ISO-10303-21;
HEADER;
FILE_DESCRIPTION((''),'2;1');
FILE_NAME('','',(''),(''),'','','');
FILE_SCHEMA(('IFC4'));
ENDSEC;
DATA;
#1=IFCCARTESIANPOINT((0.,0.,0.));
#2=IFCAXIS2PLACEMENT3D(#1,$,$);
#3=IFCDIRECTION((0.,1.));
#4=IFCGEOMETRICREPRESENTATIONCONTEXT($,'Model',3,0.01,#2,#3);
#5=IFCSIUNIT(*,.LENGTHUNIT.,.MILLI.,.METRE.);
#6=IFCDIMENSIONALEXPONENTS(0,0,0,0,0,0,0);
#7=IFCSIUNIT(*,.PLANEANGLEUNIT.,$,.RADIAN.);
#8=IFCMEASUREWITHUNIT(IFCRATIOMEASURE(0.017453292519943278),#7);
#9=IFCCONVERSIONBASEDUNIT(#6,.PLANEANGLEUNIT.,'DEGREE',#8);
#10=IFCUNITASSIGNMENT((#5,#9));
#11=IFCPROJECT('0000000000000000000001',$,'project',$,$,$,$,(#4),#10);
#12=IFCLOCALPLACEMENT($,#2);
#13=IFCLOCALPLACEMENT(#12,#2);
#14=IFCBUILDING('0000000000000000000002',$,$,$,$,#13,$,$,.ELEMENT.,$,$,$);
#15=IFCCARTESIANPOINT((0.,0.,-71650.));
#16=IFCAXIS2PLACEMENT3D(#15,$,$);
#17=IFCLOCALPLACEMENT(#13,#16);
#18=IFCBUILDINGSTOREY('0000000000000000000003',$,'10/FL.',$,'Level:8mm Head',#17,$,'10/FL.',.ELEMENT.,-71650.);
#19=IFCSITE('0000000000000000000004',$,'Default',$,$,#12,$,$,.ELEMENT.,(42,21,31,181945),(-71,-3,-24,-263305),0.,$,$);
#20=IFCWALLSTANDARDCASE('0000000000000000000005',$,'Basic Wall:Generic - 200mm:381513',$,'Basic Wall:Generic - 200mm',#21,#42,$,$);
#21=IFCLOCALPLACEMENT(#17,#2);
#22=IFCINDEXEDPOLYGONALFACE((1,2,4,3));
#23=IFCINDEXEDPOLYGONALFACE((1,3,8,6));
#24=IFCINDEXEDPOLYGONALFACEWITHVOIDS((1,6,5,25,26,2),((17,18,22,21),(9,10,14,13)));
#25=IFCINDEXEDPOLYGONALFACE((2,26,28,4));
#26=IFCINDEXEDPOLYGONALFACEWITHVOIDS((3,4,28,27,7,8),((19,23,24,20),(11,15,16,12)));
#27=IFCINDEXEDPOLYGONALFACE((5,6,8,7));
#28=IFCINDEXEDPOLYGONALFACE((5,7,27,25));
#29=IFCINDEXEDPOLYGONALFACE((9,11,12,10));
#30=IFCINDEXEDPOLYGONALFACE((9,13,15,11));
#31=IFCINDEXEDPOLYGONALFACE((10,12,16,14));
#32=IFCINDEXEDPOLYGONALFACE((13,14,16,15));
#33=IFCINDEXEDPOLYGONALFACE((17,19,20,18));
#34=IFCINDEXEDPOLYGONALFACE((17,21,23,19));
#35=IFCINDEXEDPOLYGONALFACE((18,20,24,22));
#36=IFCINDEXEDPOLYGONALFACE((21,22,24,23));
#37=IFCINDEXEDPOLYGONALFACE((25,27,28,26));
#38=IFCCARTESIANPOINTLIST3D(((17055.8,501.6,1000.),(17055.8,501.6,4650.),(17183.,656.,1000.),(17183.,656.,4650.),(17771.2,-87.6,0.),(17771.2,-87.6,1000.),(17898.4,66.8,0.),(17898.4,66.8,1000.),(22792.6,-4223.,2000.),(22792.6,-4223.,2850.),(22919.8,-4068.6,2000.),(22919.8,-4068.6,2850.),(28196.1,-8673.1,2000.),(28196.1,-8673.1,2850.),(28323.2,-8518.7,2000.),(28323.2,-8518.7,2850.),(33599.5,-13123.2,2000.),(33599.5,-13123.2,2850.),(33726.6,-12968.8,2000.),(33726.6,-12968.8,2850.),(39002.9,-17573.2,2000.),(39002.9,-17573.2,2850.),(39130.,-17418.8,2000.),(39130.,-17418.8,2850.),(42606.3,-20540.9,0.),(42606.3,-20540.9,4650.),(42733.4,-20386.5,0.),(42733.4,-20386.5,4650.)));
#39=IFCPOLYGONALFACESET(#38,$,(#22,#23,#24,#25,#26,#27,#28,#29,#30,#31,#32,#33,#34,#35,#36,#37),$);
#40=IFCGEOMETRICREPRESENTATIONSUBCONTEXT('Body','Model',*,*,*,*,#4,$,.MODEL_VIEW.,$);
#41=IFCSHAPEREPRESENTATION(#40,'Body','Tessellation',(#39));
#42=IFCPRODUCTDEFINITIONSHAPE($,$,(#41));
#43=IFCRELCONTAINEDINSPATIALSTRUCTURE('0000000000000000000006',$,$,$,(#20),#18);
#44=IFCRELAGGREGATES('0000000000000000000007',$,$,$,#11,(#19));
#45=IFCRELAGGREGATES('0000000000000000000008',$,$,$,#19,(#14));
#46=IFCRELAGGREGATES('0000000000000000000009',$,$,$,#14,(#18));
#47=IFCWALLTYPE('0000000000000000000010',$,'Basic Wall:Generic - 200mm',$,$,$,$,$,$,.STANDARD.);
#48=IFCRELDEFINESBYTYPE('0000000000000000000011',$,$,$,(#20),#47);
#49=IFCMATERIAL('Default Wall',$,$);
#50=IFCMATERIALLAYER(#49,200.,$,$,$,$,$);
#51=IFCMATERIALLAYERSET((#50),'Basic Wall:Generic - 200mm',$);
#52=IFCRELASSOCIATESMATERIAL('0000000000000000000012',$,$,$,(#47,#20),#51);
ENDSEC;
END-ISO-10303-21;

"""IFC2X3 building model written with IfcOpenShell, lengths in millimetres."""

from ifc_helpers import new_model, entity, si_unit, converted_unit, direction, frame, frame_2d, origin, place, context, subcontext, project, spatial, rectangle, extrude, material, layer, layer_set, layer_usage, type_object, element, save


model = new_model("IFC2X3")

# Units and contexts
model_context = context("Model", 3, precision=0.01, world=origin(), true_north=direction((0.0, 1.0)))
body_context = subcontext(model_context, "Body", "Model", "MODEL_VIEW")
ifc_project = project(units=[si_unit("LENGTHUNIT", "METRE", prefix="MILLI"), converted_unit("PLANEANGLEUNIT", "DEGREE", entity("IfcRatioMeasure", 0.017453292519943278), si_unit("PLANEANGLEUNIT", "RADIAN"), dimensions=[0, 0, 0, 0, 0, 0, 0])], contexts=[model_context])

# Site, building, storey
site_placement = place(None, origin())
site = spatial("IfcSite", under=ifc_project, at=site_placement, Name="Default", CompositionType="ELEMENT", RefLatitude=(42, 21, 31, 181945), RefLongitude=(-71, -3, -24, -263305), RefElevation=0.0)
building_placement = place(site_placement, origin())
building = spatial("IfcBuilding", under=site, at=building_placement, CompositionType="ELEMENT")
storey_placement = place(building_placement, frame((0.0, 0.0, -71650.0)))
storey = spatial("IfcBuildingStorey", under=building, at=storey_placement, Name="10/FL.", ObjectType="Level:8mm Head", LongName="10/FL.", CompositionType="ELEMENT", Elevation=-71650.0)

# Wall, openings
ifc_material_1 = material(Name="Default Wall")
ifc_layer = layer(ifc_material_1, 200.0)
ifc_layer_set = layer_set([ifc_layer], Name="Basic Wall:Generic - 200mm")
ifc_layer_usage = layer_usage(ifc_layer_set, "AXIS2", "NEGATIVE", 100.0)
wall_type = type_object("IfcWallType", Name="Basic Wall:Generic - 200mm", PredefinedType="STANDARD", material=ifc_layer_set)
wall_1_placement = place(storey_placement, frame((42669.9, -20463.7, 0.0), z_axis=(0.0, 0.0, 1.0), x_axis=(-0.771917, 0.635723, 0.0)))
wall_1 = element("IfcWallStandardCase", 1, at=wall_1_placement, inside=storey, type_object=wall_type, material=ifc_layer_usage, Name="Basic Wall:Generic - 200mm:381513", ObjectType="Basic Wall:Generic - 200mm", context=body_context, shape_type="SweptSolid", body=[
    extrude(rectangle(XDim=33100.0, YDim=200.0, at=frame_2d((16550.0, 0.0), x_axis=(-1.0, 0.0))), origin(), (0.0, 0.0, 1.0), 4650.0),
])
opening_1_placement = place(wall_1_placement, origin())
element("IfcOpeningElement", 2, at=opening_1_placement, cuts=wall_1, ObjectType="Opening", context=body_context, shape_type="SweptSolid", body=[
    extrude(rectangle(XDim=850.0, YDim=7000.0, at=frame_2d((0.0, 0.0), x_axis=(1.0, 0.0))), frame((8168.1, -100.0, 2425.0), z_axis=(0.0, 1.0, 0.0), x_axis=(0.0, 0.0, -1.0)), (0.0, 0.0, 1.0), 200.0),
])
opening_2_placement = place(wall_1_placement, origin())
element("IfcOpeningElement", 3, at=opening_2_placement, cuts=wall_1, ObjectType="Opening", context=body_context, shape_type="SweptSolid", body=[
    extrude(rectangle(XDim=850.0, YDim=7000.0, at=frame_2d((0.0, 0.0), x_axis=(1.0, 0.0))), frame((22168.1, -100.0, 2425.0), z_axis=(0.0, 1.0, 0.0), x_axis=(0.0, 0.0, -1.0)), (0.0, 0.0, 1.0), 200.0),
])
opening_3_placement = place(wall_1_placement, frame((45946.8, 11330.0, 0.0), z_axis=(0.0, 0.0, 1.0), x_axis=(-0.771917, -0.635723, 0.0)))
element("IfcOpeningElement", 4, at=opening_3_placement, cuts=wall_1, ObjectType="Opening", context=body_context, shape_type="SweptSolid", body=[
    extrude(rectangle(XDim=1000.0, YDim=1010.1, at=frame_2d((0.0, 0.0), x_axis=(1.0, 0.0))), frame((17516.6, 397.7, 500.0), z_axis=(-0.635723, -0.771917, 0.0), x_axis=(0.0, 0.0, -1.0)), (0.0, 0.0, 1.0), 1012.7),
])

save(model, "model.ifc")
